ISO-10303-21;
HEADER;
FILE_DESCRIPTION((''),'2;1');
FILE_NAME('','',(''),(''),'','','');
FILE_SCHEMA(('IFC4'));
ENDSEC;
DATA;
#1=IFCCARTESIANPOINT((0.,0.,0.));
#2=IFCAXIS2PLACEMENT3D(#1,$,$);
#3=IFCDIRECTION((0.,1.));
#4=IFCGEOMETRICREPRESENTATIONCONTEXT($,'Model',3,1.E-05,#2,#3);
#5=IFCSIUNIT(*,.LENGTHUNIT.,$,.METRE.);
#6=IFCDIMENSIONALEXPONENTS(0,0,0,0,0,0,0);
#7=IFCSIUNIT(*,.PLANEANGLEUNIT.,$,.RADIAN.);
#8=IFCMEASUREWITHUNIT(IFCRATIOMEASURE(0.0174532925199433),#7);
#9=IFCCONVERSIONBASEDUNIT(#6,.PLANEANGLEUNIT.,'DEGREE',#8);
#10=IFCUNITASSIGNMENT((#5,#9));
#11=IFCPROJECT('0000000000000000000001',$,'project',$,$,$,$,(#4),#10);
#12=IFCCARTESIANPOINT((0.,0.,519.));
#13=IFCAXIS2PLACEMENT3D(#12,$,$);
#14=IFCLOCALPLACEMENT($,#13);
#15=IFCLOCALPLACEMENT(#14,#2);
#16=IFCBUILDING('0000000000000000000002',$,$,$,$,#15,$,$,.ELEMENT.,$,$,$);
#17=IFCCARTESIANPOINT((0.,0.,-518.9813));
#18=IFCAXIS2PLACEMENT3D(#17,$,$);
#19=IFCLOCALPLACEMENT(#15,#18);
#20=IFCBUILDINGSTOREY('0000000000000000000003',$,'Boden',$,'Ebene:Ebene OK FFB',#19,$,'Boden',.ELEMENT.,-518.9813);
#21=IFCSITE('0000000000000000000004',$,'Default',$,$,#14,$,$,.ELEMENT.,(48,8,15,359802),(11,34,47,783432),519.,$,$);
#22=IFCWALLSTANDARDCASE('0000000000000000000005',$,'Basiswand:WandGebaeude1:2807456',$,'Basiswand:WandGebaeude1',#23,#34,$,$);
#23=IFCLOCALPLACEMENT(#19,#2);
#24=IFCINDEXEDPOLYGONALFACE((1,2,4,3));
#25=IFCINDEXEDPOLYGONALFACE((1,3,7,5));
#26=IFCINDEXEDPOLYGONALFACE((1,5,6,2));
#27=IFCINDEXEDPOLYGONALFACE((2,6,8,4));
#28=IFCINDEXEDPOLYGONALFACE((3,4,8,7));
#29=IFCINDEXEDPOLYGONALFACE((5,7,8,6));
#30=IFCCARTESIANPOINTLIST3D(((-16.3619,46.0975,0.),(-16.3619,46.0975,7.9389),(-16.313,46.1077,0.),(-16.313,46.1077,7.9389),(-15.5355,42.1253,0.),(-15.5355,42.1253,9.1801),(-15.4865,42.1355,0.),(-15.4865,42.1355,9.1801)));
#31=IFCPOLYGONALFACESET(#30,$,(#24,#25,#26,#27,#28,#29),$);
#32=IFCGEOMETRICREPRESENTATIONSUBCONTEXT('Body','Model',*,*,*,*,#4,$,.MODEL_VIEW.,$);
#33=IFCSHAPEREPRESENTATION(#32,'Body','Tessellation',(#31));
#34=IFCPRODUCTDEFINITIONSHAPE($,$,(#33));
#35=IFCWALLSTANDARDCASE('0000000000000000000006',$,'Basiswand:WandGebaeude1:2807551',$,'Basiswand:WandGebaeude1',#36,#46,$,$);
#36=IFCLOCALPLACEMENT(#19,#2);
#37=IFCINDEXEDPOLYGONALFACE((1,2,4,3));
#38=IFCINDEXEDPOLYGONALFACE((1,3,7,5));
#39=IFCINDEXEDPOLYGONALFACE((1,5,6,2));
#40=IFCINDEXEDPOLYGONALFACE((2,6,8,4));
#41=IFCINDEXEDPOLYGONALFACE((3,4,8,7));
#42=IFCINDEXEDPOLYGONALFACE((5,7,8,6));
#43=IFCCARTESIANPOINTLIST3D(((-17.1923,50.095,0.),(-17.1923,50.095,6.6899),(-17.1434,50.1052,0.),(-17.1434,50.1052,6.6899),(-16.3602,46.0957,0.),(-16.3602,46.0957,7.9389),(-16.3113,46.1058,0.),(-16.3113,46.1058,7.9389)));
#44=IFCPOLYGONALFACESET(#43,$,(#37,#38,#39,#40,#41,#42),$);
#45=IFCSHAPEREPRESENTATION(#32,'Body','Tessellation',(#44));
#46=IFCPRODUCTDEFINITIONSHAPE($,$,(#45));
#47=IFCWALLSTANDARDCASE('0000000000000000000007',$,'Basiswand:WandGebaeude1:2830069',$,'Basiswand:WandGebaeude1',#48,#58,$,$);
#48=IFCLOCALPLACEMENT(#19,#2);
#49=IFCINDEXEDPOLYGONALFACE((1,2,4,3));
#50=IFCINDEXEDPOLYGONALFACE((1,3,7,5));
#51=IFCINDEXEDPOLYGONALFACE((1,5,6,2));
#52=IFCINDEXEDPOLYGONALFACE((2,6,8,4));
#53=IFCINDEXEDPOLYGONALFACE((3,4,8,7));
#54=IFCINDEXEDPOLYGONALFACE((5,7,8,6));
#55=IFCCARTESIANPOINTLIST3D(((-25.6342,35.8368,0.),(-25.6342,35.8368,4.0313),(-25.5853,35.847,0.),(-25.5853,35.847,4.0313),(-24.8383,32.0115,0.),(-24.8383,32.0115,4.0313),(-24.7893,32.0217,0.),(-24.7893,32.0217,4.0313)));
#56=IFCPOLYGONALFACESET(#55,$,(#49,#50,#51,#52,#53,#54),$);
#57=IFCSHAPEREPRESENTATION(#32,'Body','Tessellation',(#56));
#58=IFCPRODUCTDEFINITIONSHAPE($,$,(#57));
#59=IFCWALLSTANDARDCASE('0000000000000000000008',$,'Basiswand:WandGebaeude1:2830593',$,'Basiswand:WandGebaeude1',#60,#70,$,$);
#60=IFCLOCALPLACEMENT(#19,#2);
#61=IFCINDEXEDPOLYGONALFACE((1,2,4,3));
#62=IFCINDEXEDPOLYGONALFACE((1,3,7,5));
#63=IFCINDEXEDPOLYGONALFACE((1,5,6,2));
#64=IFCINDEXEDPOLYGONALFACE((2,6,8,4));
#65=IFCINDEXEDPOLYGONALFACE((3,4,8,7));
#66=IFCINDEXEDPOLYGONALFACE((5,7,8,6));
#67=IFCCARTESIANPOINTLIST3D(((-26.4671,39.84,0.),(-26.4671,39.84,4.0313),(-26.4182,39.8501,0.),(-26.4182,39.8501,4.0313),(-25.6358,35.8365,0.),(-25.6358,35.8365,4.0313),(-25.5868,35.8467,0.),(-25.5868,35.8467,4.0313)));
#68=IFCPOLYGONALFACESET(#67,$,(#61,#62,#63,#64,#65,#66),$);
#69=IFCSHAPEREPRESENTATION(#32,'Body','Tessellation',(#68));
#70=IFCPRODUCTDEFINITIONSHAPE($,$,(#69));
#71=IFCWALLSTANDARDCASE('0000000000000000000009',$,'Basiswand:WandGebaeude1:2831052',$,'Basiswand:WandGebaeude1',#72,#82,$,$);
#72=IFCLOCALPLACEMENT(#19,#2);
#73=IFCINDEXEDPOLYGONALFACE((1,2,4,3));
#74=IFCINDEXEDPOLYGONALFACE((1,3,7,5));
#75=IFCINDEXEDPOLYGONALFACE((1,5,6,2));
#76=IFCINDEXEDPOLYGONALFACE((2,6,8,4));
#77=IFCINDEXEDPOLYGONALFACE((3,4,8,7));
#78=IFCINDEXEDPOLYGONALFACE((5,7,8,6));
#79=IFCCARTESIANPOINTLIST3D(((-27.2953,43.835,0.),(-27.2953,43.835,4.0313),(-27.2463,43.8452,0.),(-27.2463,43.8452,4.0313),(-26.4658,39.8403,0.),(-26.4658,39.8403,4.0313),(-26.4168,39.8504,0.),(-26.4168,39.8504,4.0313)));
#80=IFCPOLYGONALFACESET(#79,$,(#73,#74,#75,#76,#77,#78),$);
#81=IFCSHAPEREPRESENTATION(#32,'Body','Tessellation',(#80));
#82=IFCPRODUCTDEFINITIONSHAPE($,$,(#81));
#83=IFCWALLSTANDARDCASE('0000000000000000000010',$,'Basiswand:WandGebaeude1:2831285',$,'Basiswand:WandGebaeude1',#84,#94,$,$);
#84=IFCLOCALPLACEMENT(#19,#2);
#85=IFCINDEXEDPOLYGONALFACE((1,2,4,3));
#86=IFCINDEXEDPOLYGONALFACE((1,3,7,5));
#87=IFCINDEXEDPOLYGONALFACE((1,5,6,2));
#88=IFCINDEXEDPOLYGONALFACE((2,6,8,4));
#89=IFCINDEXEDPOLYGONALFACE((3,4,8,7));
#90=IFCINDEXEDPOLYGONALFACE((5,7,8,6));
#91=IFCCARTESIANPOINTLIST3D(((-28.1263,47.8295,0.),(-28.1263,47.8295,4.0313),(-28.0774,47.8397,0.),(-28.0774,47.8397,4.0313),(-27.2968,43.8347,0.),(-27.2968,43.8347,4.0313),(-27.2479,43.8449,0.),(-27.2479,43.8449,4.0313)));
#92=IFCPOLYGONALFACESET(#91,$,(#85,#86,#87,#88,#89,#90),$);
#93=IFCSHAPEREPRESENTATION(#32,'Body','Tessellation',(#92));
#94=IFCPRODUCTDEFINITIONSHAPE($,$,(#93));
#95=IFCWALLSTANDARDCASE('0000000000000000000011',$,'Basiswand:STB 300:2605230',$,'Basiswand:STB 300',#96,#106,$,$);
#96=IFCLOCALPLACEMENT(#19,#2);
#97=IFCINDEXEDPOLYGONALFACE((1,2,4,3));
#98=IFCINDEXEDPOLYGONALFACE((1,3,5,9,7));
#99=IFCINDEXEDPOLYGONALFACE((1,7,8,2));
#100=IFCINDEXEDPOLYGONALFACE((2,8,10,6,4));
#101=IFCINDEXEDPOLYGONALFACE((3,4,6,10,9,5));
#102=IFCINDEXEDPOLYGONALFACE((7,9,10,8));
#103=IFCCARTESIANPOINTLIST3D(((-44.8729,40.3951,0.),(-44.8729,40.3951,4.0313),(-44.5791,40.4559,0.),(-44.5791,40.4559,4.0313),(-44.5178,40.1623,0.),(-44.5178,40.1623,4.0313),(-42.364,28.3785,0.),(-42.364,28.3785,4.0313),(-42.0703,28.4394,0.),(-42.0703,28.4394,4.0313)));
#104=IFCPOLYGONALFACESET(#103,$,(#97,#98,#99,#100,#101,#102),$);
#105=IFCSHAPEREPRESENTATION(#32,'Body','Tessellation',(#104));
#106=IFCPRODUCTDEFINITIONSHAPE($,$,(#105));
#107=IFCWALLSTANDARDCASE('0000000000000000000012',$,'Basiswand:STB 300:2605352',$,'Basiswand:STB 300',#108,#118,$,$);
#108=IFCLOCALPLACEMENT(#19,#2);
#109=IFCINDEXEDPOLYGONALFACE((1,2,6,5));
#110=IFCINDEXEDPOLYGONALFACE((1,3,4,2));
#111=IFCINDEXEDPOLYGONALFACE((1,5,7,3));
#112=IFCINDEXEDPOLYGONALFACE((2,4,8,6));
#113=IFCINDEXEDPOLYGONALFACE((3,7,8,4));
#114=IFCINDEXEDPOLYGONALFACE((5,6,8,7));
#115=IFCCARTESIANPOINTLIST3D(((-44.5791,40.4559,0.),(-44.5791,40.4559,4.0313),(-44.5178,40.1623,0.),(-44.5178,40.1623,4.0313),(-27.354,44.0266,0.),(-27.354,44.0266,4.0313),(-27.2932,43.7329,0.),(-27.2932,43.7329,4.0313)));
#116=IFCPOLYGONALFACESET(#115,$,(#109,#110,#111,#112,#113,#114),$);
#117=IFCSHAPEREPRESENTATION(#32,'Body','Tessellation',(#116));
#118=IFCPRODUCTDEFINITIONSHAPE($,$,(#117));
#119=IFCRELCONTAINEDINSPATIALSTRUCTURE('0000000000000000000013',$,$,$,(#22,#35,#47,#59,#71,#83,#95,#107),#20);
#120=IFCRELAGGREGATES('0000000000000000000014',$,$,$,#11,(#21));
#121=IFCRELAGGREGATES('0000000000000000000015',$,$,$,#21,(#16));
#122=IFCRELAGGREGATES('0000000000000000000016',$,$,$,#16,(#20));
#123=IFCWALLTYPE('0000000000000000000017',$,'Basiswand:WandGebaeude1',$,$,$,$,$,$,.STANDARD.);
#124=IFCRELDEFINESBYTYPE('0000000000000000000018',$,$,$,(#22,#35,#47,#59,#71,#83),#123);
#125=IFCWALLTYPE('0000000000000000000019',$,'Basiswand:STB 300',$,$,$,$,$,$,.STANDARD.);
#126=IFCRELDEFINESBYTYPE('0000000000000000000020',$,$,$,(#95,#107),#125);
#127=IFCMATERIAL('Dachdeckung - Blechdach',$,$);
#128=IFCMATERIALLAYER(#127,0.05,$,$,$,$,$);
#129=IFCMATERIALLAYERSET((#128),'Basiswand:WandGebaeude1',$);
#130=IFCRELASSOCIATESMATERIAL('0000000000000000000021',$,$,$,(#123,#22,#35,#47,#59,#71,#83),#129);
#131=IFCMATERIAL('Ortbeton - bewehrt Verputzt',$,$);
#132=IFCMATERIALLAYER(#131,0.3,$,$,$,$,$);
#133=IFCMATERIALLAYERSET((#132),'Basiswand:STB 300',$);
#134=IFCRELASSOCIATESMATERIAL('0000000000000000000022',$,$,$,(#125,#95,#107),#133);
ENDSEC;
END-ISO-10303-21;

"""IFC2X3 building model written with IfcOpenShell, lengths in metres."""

from ifc_helpers import new_model, entity, si_unit, converted_unit, direction, frame, frame_2d, origin, place, context, subcontext, project, spatial, polyline, rectangle, outline, extrude, clip, halfspace, material, layer, layer_set, layer_usage, type_object, element, save


model = new_model("IFC2X3")

# Units and contexts
model_context = context("Model", 3, precision=1e-05, world=origin(), true_north=direction((0.0, 1.0)))
body_context = subcontext(model_context, "Body", "Model", "MODEL_VIEW")
ifc_project = project(units=[si_unit("LENGTHUNIT", "METRE"), converted_unit("PLANEANGLEUNIT", "DEGREE", entity("IfcRatioMeasure", 0.0174532925199433), si_unit("PLANEANGLEUNIT", "RADIAN"), dimensions=[0, 0, 0, 0, 0, 0, 0])], contexts=[model_context])

# Site, building, storey
site_placement = place(None, frame((0.0, 0.0, 519.0)))
site = spatial("IfcSite", under=ifc_project, at=site_placement, Name="Default", CompositionType="ELEMENT", RefLatitude=(48, 8, 15, 359802), RefLongitude=(11, 34, 47, 783432), RefElevation=519.0)
building_placement = place(site_placement, origin())
building = spatial("IfcBuilding", under=site, at=building_placement, CompositionType="ELEMENT")
storey_placement = place(building_placement, frame((0.0, 0.0, -518.9813)))
storey = spatial("IfcBuildingStorey", under=building, at=storey_placement, Name="Boden", ObjectType="Ebene:Ebene OK FFB", LongName="Boden", CompositionType="ELEMENT", Elevation=-518.9813)

# Walls
ifc_material_1 = material(Name="Dachdeckung - Blechdach")
ifc_layer_1 = layer(ifc_material_1, 0.05)
ifc_layer_set_1 = layer_set([ifc_layer_1], Name="Basiswand:WandGebaeude1")
wall_type_1 = type_object("IfcWallType", Name="Basiswand:WandGebaeude1", PredefinedType="STANDARD", material=ifc_layer_set_1)
ifc_layer_usage_1 = layer_usage(ifc_layer_set_1, "AXIS2", "NEGATIVE", 0.025)
wall_1_placement = place(storey_placement, frame((-15.511, 42.1304, 0.0), z_axis=(0.0, 0.0, 1.0), x_axis=(-0.203696, 0.979034, 0.0)))
element("IfcWallStandardCase", 1, at=wall_1_placement, inside=storey, type_object=wall_type_1, material=ifc_layer_usage_1, Name="Basiswand:WandGebaeude1:2807456", ObjectType="Basiswand:WandGebaeude1", context=body_context, shape_type="Clipping", body=[
    clip(extrude(rectangle(XDim=4.0572, YDim=0.05, at=frame_2d((2.0286, 0.0), x_axis=(-1.0, 0.0))), origin(), (0.0, 0.0, 1.0), 9.1801), halfspace(frame((0.0, -0.025, 9.1801), z_axis=(0.292554, 0.0, 0.956249), x_axis=(0.0, 1.0, 0.0)), False)),
])
ifc_layer_usage_2 = layer_usage(ifc_layer_set_1, "AXIS2", "NEGATIVE", 0.025)
wall_2_placement = place(storey_placement, frame((-16.3357, 46.1007, 0.0), z_axis=(0.0, 0.0, 1.0), x_axis=(-0.203696, 0.979034, 0.0)))
element("IfcWallStandardCase", 2, at=wall_2_placement, inside=storey, type_object=wall_type_1, material=ifc_layer_usage_2, Name="Basiswand:WandGebaeude1:2807551", ObjectType="Basiswand:WandGebaeude1", context=body_context, shape_type="Clipping", body=[
    clip(extrude(rectangle(XDim=4.085, YDim=0.05, at=frame_2d((2.0425, 0.0), x_axis=(-1.0, 0.0))), origin(), (0.0, 0.0, 1.0), 7.9389), halfspace(frame((0.0, -0.025, 7.9389), z_axis=(0.292372, 0.0, 0.956305), x_axis=(0.0, 1.0, 0.0)), False)),
])
ifc_layer_usage_3 = layer_usage(ifc_layer_set_1, "AXIS2", "NEGATIVE", 0.025)
wall_3_placement = place(storey_placement, frame((-24.8138, 32.0166, 0.0), z_axis=(0.0, 0.0, 1.0), x_axis=(-0.203711, 0.979031, 0.0)))
element("IfcWallStandardCase", 3, at=wall_3_placement, inside=storey, type_object=wall_type_1, material=ifc_layer_usage_3, Name="Basiswand:WandGebaeude1:2830069", ObjectType="Basiswand:WandGebaeude1", context=body_context, shape_type="SweptSolid", body=[
    extrude(outline(polyline([(3.9072, -0.025), (3.9072, 0.025), (0.0, 0.025), (0.0, -0.025), (3.9072, -0.025)])), origin(), (0.0, 0.0, 1.0), 4.0313),
])
ifc_layer_usage_4 = layer_usage(ifc_layer_set_1, "AXIS2", "NEGATIVE", 0.025)
wall_4_placement = place(storey_placement, frame((-25.6113, 35.8416, 0.0), z_axis=(0.0, 0.0, 1.0), x_axis=(-0.203311, 0.979114, 0.0)))
element("IfcWallStandardCase", 4, at=wall_4_placement, inside=storey, type_object=wall_type_1, material=ifc_layer_usage_4, Name="Basiswand:WandGebaeude1:2830593", ObjectType="Basiswand:WandGebaeude1", context=body_context, shape_type="SweptSolid", body=[
    extrude(rectangle(XDim=4.0889, YDim=0.05, at=frame_2d((2.0444, 0.0), x_axis=(-1.0, 0.0))), origin(), (0.0, 0.0, 1.0), 4.0313),
])
ifc_layer_usage_5 = layer_usage(ifc_layer_set_1, "AXIS2", "NEGATIVE", 0.025)
wall_5_placement = place(storey_placement, frame((-26.4413, 39.8453, 0.0), z_axis=(0.0, 0.0, 1.0), x_axis=(-0.203311, 0.979114, 0.0)))
element("IfcWallStandardCase", 5, at=wall_5_placement, inside=storey, type_object=wall_type_1, material=ifc_layer_usage_5, Name="Basiswand:WandGebaeude1:2831052", ObjectType="Basiswand:WandGebaeude1", context=body_context, shape_type="SweptSolid", body=[
    extrude(rectangle(XDim=4.08, YDim=0.05, at=frame_2d((2.04, 0.0), x_axis=(-1.0, 0.0))), origin(), (0.0, 0.0, 1.0), 4.0313),
])
ifc_layer_usage_6 = layer_usage(ifc_layer_set_1, "AXIS2", "NEGATIVE", 0.025)
wall_6_placement = place(storey_placement, frame((-27.2724, 43.8398, 0.0), z_axis=(0.0, 0.0, 1.0), x_axis=(-0.203311, 0.979114, 0.0)))
element("IfcWallStandardCase", 6, at=wall_6_placement, inside=storey, type_object=wall_type_1, material=ifc_layer_usage_6, Name="Basiswand:WandGebaeude1:2831285", ObjectType="Basiswand:WandGebaeude1", context=body_context, shape_type="SweptSolid", body=[
    extrude(rectangle(XDim=4.08, YDim=0.05, at=frame_2d((2.04, 0.0), x_axis=(-1.0, 0.0))), origin(), (0.0, 0.0, 1.0), 4.0313),
])
ifc_material_2 = material(Name="Ortbeton - bewehrt Verputzt")
ifc_layer_2 = layer(ifc_material_2, 0.3)
ifc_layer_set_2 = layer_set([ifc_layer_2], Name="Basiswand:STB 300")
ifc_layer_usage_7 = layer_usage(ifc_layer_set_2, "AXIS2", "NEGATIVE", 0.15)
wall_type_2 = type_object("IfcWallType", Name="Basiswand:STB 300", PredefinedType="STANDARD", material=ifc_layer_set_2)
wall_7_placement = place(storey_placement, frame((-42.2171, 28.4088, 0.0), z_axis=(0.0, 0.0, 1.0), x_axis=(-0.204377, 0.978892, 0.0)))
element("IfcWallStandardCase", 7, at=wall_7_placement, inside=storey, type_object=wall_type_2, material=ifc_layer_usage_7, Name="Basiswand:STB 300:2605230", ObjectType="Basiswand:STB 300", context=body_context, shape_type="SweptSolid", body=[
    extrude(outline(polyline([(12.2756, -0.15), (12.2761, 0.15), (0.0004, 0.15), (0.0, -0.15), (11.9756, -0.15), (12.2756, -0.15)])), origin(), (0.0, 0.0, 1.0), 4.0313),
])
ifc_layer_usage_8 = layer_usage(ifc_layer_set_2, "AXIS2", "NEGATIVE", 0.15)
wall_8_placement = place(storey_placement, frame((-44.5487, 40.3091, 0.0), z_axis=(0.0, 0.0, 1.0), x_axis=(0.979183, 0.20298, 0.0)))
element("IfcWallStandardCase", 8, at=wall_8_placement, inside=storey, type_object=wall_type_2, material=ifc_layer_usage_8, Name="Basiswand:STB 300:2605352", ObjectType="Basiswand:STB 300", context=body_context, shape_type="SweptSolid", body=[
    extrude(outline(polyline([(17.5913, -0.15), (17.5913, 0.15), (0.0, 0.15), (0.0004, -0.15), (17.5913, -0.15)])), origin(), (0.0, 0.0, 1.0), 4.0313),
])

save(model, "model.ifc")
